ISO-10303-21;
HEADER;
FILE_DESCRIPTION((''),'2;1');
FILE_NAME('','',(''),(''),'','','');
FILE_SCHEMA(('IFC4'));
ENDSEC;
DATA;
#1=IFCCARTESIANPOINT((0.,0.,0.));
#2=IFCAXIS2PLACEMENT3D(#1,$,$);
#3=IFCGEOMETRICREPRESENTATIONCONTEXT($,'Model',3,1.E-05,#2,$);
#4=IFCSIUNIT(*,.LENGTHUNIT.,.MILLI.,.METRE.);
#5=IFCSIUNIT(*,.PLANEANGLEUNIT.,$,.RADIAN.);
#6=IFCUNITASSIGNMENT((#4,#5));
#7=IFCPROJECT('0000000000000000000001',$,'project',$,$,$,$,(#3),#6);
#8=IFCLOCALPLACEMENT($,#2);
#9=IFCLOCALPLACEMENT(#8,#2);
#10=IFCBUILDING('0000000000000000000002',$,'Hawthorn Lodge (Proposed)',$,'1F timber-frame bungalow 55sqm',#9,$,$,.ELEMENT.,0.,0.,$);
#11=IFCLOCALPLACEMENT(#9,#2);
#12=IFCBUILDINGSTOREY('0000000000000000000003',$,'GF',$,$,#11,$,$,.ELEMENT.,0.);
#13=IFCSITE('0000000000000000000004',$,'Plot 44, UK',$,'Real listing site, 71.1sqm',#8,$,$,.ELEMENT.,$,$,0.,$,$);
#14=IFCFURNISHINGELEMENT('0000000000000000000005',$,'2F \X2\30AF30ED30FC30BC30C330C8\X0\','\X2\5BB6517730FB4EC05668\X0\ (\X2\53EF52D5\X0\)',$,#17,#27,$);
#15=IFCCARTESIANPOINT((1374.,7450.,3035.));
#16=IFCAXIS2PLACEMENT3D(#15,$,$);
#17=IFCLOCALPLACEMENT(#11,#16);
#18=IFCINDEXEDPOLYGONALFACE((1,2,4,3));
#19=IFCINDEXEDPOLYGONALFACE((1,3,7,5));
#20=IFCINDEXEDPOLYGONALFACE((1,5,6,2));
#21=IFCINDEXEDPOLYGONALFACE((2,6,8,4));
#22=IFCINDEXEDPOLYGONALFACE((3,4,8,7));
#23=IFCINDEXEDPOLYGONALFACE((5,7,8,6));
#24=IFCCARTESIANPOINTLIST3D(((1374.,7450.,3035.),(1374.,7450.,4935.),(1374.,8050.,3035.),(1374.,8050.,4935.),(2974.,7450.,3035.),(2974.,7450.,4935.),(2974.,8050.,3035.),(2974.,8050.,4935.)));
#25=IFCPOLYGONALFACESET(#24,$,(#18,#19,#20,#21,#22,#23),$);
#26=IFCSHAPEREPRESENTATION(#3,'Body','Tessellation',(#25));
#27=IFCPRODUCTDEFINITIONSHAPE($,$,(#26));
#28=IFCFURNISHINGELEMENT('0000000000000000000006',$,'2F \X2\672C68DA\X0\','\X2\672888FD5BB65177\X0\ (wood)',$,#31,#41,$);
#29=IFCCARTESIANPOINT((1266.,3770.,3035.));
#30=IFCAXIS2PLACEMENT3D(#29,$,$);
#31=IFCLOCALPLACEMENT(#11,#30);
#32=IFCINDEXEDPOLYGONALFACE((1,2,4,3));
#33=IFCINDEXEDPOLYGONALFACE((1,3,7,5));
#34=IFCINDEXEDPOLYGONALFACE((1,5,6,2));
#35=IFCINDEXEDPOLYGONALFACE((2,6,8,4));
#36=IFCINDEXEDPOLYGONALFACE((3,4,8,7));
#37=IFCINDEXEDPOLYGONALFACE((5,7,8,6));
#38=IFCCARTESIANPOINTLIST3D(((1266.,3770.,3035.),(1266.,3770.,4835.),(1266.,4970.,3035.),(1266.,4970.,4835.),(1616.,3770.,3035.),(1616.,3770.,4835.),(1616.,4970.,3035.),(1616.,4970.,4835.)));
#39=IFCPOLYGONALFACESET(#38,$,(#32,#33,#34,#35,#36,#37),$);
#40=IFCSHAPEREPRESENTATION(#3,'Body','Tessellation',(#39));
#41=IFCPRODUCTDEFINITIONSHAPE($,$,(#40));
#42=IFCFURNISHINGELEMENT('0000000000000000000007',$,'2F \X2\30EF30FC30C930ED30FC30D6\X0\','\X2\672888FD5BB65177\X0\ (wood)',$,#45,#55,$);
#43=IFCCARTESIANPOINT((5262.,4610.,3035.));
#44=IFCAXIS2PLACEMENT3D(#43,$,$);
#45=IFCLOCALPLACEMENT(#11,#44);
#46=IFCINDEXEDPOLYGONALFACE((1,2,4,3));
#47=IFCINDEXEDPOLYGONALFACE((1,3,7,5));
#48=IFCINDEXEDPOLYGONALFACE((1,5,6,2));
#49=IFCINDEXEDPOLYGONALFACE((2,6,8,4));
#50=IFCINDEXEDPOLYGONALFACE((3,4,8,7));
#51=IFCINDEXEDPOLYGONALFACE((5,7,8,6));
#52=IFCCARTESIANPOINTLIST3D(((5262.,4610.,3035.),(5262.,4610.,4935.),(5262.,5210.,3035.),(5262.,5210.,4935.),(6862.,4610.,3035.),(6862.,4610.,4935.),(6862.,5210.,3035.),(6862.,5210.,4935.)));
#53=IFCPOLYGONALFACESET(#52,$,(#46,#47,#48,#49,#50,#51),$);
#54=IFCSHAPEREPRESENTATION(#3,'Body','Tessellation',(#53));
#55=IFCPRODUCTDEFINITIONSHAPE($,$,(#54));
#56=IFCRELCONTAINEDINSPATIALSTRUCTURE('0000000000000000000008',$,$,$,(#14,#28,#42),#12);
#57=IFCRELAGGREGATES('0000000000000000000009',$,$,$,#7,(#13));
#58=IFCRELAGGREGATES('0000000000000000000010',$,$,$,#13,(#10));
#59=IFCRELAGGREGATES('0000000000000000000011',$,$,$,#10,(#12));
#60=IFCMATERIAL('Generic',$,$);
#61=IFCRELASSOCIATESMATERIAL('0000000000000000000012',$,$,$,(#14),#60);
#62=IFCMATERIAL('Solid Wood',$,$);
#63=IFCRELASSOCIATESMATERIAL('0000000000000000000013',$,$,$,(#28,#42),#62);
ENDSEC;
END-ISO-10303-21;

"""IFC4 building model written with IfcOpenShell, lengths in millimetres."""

from ifc_helpers import new_model, si_unit, frame, frame_2d, origin, place, context, project, spatial, rectangle, extrude, material, element, save


model = new_model("IFC4")

# Units and contexts
model_context = context("Model", 3, precision=1e-05, world=origin())
ifc_project = project(units=[si_unit("LENGTHUNIT", "METRE", prefix="MILLI"), si_unit("PLANEANGLEUNIT", "RADIAN")], contexts=[model_context])

# Site, building, storey
site_placement = place(None, origin())
site = spatial("IfcSite", under=ifc_project, at=site_placement, Name="Plot 44, UK", ObjectType="Real listing site, 71.1sqm", CompositionType="ELEMENT", RefElevation=0.0)
building_placement = place(site_placement, origin())
building = spatial("IfcBuilding", under=site, at=building_placement, Name="Hawthorn Lodge (Proposed)", ObjectType="1F timber-frame bungalow 55sqm", CompositionType="ELEMENT", ElevationOfRefHeight=0.0, ElevationOfTerrain=0.0)
storey_placement = place(building_placement, origin())
storey = spatial("IfcBuildingStorey", under=building, at=storey_placement, Name="GF", CompositionType="ELEMENT", Elevation=0.0)

# Shared definitions
ifc_material_1 = material(Name="Solid Wood")

# Shared definitions
ifc_material_2 = material(Name="Generic")

# Furnishing elements
furnishing_1_placement = place(storey_placement, frame((1374.0, 7450.0, 3035.0)))
element("IfcFurnishingElement", 1, at=furnishing_1_placement, inside=storey, material=ifc_material_2, Name="2F クローゼット", Description="家具・什器 (可動)", context=model_context, shape_type="SweptSolid", body=[
    extrude(rectangle(XDim=1600.0, YDim=600.0, at=frame_2d((800.0, 300.0))), frame((1374.0, 7450.0, 3035.0)), (0.0, 0.0, 1.0), 1900.0),
])
furnishing_2_placement = place(storey_placement, frame((1266.0, 3770.0, 3035.0)))
element("IfcFurnishingElement", 2, at=furnishing_2_placement, inside=storey, material=ifc_material_1, Name="2F 本棚", Description="木製家具 (wood)", context=model_context, shape_type="SweptSolid", body=[
    extrude(rectangle(XDim=350.0, YDim=1200.0, at=frame_2d((175.0, 600.0))), frame((1266.0, 3770.0, 3035.0)), (0.0, 0.0, 1.0), 1800.0),
])
furnishing_3_placement = place(storey_placement, frame((5262.0, 4610.0, 3035.0)))
element("IfcFurnishingElement", 3, at=furnishing_3_placement, inside=storey, material=ifc_material_1, Name="2F ワードローブ", Description="木製家具 (wood)", context=model_context, shape_type="SweptSolid", body=[
    extrude(rectangle(XDim=1600.0, YDim=600.0, at=frame_2d((800.0, 300.0))), frame((5262.0, 4610.0, 3035.0)), (0.0, 0.0, 1.0), 1900.0),
])

save(model, "model.ifc")
